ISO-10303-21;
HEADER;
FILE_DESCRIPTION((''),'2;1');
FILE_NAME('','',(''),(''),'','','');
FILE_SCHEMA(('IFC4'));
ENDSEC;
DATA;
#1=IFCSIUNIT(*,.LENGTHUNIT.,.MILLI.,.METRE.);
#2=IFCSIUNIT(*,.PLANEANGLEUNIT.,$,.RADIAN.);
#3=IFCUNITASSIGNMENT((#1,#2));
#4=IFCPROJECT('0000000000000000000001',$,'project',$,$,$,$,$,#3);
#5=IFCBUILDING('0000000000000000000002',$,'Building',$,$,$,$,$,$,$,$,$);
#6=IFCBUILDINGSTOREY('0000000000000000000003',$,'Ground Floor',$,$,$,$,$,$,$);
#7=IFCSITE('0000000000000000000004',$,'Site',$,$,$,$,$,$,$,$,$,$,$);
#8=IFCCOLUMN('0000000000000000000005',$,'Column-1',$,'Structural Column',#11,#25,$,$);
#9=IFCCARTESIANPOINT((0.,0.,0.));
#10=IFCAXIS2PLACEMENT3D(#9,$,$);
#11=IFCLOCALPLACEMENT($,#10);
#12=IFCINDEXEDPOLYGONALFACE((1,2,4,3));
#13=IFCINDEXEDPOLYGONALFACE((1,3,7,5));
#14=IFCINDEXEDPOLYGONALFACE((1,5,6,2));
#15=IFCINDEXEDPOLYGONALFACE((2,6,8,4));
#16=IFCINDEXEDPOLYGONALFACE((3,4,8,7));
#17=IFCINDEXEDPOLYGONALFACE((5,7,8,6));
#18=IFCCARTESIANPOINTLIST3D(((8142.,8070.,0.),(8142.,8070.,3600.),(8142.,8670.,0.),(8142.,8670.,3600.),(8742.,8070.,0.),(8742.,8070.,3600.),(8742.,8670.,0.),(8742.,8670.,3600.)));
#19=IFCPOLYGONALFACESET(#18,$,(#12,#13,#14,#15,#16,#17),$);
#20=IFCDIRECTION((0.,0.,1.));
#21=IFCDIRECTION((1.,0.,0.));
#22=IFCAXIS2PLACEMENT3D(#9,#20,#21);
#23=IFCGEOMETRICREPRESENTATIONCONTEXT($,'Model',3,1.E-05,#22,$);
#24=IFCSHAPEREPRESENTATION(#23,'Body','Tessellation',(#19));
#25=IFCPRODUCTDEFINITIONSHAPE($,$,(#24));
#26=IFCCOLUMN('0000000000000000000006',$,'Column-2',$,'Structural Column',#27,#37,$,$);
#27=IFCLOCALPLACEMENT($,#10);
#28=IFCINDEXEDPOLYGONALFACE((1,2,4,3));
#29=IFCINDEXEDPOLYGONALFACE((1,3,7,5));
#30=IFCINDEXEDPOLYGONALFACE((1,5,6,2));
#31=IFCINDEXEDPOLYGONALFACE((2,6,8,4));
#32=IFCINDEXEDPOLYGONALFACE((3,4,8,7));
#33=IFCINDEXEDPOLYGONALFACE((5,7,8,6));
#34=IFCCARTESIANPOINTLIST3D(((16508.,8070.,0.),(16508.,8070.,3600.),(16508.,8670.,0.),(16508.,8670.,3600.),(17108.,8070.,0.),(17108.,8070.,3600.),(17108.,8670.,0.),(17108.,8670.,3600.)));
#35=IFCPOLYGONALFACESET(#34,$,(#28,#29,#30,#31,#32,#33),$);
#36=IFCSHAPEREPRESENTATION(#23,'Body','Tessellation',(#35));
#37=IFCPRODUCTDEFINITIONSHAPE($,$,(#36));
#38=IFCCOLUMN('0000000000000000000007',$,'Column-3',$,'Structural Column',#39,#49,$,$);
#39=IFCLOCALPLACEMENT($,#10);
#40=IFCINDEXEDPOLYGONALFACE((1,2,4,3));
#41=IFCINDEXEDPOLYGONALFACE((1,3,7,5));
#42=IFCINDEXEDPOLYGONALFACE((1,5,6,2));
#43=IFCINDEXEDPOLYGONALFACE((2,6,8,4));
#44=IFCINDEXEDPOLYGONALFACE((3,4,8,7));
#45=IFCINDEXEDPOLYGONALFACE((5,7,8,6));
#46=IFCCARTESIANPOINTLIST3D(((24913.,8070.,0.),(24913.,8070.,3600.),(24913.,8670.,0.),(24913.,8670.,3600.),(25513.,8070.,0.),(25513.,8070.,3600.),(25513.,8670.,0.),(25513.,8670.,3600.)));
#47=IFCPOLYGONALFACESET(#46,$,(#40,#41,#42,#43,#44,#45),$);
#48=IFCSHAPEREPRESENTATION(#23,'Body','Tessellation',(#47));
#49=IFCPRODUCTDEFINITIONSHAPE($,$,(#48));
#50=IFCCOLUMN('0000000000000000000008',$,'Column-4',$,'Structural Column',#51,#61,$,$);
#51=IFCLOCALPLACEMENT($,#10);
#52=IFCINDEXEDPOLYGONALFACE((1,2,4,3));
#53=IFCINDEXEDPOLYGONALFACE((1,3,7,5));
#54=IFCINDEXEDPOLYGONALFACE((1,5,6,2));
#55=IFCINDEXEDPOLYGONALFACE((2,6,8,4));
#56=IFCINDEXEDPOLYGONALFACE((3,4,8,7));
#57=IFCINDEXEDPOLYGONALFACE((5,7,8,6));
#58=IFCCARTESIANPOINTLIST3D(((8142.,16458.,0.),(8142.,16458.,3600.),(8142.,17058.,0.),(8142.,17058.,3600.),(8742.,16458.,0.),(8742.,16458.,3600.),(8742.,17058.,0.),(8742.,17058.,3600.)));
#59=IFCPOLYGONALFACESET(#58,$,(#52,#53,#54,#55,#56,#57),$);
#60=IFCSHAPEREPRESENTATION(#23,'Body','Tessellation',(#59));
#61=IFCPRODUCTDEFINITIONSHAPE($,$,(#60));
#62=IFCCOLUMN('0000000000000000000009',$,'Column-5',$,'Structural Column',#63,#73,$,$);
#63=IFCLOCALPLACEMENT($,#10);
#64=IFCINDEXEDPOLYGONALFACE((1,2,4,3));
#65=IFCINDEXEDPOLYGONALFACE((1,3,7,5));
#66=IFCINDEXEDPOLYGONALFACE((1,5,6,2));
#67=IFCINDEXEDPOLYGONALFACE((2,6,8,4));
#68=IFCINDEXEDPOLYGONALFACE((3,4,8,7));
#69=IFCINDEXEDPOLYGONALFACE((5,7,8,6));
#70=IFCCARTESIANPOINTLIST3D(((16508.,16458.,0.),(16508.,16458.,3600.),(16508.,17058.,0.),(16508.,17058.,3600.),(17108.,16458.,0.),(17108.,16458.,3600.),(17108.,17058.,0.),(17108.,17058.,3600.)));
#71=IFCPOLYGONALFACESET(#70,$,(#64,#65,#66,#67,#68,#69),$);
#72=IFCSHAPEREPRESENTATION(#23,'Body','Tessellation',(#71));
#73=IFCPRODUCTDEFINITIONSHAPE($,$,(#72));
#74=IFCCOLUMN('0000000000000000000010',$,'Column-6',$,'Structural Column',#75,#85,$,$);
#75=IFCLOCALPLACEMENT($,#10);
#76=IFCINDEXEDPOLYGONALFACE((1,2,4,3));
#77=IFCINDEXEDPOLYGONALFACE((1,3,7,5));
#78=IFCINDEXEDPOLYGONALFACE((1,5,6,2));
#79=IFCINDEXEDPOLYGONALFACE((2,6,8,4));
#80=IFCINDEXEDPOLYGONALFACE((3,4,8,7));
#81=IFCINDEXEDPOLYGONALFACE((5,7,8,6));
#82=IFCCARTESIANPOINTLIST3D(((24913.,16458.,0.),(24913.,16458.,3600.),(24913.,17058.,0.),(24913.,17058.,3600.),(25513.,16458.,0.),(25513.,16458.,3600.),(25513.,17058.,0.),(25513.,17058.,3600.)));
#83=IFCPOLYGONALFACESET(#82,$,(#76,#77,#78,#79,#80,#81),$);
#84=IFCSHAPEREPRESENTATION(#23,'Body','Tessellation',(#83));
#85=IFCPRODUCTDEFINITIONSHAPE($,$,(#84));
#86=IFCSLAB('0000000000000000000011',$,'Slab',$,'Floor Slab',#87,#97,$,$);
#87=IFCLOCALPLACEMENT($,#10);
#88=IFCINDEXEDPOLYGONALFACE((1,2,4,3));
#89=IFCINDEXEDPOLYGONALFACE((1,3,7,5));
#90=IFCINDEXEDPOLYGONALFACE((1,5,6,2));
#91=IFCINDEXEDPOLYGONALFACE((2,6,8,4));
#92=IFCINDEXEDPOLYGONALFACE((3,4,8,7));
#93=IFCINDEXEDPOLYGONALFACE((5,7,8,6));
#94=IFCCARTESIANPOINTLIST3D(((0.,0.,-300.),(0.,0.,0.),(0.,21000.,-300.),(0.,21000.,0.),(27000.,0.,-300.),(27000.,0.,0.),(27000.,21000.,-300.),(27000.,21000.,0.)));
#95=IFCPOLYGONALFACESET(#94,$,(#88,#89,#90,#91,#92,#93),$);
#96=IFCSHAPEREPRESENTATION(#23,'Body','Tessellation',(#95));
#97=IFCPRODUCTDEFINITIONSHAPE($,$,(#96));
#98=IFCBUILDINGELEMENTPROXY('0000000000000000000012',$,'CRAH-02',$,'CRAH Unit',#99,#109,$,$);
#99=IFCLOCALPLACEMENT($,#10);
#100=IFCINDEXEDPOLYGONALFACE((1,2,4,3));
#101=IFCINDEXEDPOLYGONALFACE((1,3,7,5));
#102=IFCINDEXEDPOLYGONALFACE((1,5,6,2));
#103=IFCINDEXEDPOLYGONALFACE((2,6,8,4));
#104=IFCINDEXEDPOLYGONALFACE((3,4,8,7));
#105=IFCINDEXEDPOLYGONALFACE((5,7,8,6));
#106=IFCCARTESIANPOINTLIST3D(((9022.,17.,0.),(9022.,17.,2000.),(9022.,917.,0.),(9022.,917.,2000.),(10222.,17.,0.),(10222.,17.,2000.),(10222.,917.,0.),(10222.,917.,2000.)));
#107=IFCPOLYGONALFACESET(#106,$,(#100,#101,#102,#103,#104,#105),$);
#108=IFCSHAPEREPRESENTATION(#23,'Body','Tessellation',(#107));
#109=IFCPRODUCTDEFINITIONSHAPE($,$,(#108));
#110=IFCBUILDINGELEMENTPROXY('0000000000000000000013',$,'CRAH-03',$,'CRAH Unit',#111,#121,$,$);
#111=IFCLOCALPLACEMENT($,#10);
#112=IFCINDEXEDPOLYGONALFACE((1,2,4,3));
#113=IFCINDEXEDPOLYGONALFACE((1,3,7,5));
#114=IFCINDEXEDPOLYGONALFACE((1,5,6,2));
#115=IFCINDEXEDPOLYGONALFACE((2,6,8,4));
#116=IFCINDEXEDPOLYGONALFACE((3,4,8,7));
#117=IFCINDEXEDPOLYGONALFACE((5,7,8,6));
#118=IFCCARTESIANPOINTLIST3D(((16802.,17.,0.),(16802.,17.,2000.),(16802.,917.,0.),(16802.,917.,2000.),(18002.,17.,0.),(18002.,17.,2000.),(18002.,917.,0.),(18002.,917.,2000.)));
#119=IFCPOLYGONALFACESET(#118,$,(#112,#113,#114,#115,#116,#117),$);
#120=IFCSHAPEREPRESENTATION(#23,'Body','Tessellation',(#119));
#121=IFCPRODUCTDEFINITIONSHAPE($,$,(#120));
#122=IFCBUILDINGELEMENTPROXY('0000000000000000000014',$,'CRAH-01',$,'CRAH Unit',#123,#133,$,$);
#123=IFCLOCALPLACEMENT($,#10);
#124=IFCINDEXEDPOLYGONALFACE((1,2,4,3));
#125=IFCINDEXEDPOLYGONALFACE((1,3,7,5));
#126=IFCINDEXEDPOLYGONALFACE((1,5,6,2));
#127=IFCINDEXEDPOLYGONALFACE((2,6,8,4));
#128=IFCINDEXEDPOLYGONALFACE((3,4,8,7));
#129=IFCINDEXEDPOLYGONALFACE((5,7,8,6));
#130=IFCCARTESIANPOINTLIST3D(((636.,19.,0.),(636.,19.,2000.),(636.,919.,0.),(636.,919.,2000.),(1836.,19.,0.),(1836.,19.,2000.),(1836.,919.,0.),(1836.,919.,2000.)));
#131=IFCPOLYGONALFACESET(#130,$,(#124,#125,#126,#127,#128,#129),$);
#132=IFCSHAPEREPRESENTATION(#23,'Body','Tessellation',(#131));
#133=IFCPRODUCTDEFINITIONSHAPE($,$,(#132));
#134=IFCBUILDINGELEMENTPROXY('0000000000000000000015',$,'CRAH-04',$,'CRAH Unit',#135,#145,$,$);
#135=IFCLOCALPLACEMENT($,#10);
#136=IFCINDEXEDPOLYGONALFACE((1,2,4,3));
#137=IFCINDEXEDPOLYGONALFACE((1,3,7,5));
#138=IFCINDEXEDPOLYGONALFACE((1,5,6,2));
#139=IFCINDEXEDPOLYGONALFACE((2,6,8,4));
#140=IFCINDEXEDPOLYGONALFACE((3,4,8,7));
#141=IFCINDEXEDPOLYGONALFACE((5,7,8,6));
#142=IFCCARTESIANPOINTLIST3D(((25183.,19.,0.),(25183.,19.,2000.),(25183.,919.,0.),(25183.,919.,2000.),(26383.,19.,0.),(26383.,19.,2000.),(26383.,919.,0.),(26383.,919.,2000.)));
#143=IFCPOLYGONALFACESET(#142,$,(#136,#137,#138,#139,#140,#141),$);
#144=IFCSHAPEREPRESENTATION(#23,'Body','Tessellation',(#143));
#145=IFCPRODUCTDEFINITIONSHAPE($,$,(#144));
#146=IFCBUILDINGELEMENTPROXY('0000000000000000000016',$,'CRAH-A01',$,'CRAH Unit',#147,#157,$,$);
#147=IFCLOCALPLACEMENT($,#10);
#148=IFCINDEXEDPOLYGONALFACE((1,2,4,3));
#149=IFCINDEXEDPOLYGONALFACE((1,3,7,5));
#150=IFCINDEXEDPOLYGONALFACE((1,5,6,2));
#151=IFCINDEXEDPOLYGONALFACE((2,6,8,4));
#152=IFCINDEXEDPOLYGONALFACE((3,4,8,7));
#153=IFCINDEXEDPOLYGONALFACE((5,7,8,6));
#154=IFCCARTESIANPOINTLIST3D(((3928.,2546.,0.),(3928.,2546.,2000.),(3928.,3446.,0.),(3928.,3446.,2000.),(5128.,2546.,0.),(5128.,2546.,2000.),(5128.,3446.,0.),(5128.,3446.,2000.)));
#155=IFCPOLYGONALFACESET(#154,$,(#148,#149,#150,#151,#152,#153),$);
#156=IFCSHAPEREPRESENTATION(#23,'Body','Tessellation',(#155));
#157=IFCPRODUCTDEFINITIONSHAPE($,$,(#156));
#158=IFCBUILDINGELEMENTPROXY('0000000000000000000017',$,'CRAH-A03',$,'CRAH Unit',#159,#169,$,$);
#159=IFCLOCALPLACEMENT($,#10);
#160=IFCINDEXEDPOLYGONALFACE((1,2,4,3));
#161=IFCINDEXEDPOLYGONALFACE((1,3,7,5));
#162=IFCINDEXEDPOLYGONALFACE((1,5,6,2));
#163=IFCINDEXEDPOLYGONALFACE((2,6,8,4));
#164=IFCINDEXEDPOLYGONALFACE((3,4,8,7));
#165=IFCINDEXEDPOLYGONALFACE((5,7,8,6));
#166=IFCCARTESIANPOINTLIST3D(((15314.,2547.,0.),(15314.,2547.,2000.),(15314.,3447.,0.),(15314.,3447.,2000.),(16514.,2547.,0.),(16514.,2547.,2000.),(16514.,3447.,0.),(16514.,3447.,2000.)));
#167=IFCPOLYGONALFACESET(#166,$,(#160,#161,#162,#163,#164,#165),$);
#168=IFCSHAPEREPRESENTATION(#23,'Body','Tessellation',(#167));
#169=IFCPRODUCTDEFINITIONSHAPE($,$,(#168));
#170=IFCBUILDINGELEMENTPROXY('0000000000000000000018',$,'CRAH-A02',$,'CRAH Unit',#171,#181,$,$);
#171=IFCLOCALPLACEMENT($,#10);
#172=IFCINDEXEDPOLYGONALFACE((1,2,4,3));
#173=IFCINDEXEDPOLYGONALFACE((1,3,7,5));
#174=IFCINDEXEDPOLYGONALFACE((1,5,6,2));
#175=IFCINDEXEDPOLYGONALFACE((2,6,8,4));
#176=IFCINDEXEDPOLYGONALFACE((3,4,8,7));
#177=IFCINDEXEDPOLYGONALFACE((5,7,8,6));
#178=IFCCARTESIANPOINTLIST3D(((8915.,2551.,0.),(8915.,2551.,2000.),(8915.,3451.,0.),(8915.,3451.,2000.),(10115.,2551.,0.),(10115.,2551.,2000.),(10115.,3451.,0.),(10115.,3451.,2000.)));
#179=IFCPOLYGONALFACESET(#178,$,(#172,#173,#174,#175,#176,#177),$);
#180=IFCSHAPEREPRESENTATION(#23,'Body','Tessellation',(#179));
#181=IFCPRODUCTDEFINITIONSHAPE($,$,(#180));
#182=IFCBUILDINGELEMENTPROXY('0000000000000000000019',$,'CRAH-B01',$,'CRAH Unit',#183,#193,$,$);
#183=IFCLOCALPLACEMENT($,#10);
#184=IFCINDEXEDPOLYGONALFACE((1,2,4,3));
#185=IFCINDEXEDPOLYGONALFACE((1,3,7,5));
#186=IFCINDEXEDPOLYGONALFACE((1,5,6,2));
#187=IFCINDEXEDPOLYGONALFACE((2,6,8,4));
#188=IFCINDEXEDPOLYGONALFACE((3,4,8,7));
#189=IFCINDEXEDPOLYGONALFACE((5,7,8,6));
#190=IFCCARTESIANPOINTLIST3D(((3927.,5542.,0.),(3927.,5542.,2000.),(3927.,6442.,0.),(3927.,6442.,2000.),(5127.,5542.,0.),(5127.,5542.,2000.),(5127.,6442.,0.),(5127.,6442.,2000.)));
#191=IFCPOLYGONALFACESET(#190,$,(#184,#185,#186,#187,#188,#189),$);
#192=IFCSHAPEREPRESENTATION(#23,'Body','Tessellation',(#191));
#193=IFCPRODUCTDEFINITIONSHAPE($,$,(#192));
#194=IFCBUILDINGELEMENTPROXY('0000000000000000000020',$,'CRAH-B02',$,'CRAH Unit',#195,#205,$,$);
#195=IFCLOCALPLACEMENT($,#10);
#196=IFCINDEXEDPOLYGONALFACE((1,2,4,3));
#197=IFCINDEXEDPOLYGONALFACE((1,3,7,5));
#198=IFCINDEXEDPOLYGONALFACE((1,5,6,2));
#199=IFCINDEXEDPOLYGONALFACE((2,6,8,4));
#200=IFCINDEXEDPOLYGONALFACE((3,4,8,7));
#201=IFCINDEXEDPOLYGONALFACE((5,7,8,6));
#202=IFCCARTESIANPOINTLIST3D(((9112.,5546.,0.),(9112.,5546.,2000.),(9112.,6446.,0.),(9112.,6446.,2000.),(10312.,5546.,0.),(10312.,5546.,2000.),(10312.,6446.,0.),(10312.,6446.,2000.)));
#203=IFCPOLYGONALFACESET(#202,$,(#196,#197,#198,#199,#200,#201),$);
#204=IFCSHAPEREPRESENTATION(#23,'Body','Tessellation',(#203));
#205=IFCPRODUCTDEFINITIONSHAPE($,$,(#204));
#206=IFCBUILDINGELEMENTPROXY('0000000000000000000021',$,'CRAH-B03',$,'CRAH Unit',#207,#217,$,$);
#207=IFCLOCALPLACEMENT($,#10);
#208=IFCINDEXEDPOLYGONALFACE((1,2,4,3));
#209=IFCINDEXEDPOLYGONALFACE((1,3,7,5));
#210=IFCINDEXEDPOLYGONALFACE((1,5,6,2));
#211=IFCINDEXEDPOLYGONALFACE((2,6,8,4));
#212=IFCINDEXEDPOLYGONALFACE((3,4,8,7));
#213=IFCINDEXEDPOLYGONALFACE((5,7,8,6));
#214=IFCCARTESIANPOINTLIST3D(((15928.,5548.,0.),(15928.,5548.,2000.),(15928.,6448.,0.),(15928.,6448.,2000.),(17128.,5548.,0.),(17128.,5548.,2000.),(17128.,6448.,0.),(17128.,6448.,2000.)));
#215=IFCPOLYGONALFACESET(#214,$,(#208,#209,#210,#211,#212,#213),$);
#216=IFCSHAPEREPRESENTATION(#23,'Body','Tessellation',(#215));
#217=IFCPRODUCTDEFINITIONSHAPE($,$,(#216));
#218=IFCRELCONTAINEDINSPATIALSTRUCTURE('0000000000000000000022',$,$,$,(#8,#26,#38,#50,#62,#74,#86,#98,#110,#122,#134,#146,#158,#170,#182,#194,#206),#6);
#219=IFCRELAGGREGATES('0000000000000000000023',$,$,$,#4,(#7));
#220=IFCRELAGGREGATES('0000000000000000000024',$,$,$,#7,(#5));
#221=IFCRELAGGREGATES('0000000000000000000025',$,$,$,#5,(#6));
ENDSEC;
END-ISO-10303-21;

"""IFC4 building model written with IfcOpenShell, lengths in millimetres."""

from ifc_helpers import new_model, si_unit, frame, origin_with_axes, place, context, project, spatial, rectangle, extrude, element, save


model = new_model("IFC4")

# Units and contexts
model_context = context("Model", 3, precision=1e-05, world=origin_with_axes())
ifc_project = project(units=[si_unit("LENGTHUNIT", "METRE", prefix="MILLI"), si_unit("PLANEANGLEUNIT", "RADIAN")])

# Site, building, storey
site = spatial("IfcSite", under=ifc_project, Name="Site")
building = spatial("IfcBuilding", under=site, Name="Building")
storey = spatial("IfcBuildingStorey", under=building, Name="Ground Floor")

# Columns
column_1_placement = place(None, origin_with_axes())
element("IfcColumn", 1, at=column_1_placement, inside=storey, Name="Column-1", ObjectType="Structural Column", context=model_context, shape_type="SweptSolid", body=[
    extrude(rectangle(XDim=600.0, YDim=600.0), frame((8442.0, 8370.0, 0.0), z_axis=(0.0, 0.0, 1.0), x_axis=(1.0, 0.0, 0.0)), (0.0, 0.0, 1.0), 3600.0),
])
column_2_placement = place(None, origin_with_axes())
element("IfcColumn", 2, at=column_2_placement, inside=storey, Name="Column-2", ObjectType="Structural Column", context=model_context, shape_type="SweptSolid", body=[
    extrude(rectangle(XDim=600.0, YDim=600.0), frame((16808.0, 8370.0, 0.0), z_axis=(0.0, 0.0, 1.0), x_axis=(1.0, 0.0, 0.0)), (0.0, 0.0, 1.0), 3600.0),
])
column_3_placement = place(None, origin_with_axes())
element("IfcColumn", 3, at=column_3_placement, inside=storey, Name="Column-3", ObjectType="Structural Column", context=model_context, shape_type="SweptSolid", body=[
    extrude(rectangle(XDim=600.0, YDim=600.0), frame((25213.0, 8370.0, 0.0), z_axis=(0.0, 0.0, 1.0), x_axis=(1.0, 0.0, 0.0)), (0.0, 0.0, 1.0), 3600.0),
])
column_4_placement = place(None, origin_with_axes())
element("IfcColumn", 4, at=column_4_placement, inside=storey, Name="Column-4", ObjectType="Structural Column", context=model_context, shape_type="SweptSolid", body=[
    extrude(rectangle(XDim=600.0, YDim=600.0), frame((8442.0, 16758.0, 0.0), z_axis=(0.0, 0.0, 1.0), x_axis=(1.0, 0.0, 0.0)), (0.0, 0.0, 1.0), 3600.0),
])
column_5_placement = place(None, origin_with_axes())
element("IfcColumn", 5, at=column_5_placement, inside=storey, Name="Column-5", ObjectType="Structural Column", context=model_context, shape_type="SweptSolid", body=[
    extrude(rectangle(XDim=600.0, YDim=600.0), frame((16808.0, 16758.0, 0.0), z_axis=(0.0, 0.0, 1.0), x_axis=(1.0, 0.0, 0.0)), (0.0, 0.0, 1.0), 3600.0),
])
column_6_placement = place(None, origin_with_axes())
element("IfcColumn", 6, at=column_6_placement, inside=storey, Name="Column-6", ObjectType="Structural Column", context=model_context, shape_type="SweptSolid", body=[
    extrude(rectangle(XDim=600.0, YDim=600.0), frame((25213.0, 16758.0, 0.0), z_axis=(0.0, 0.0, 1.0), x_axis=(1.0, 0.0, 0.0)), (0.0, 0.0, 1.0), 3600.0),
])

# Slab
slab_placement = place(None, origin_with_axes())
element("IfcSlab", 7, at=slab_placement, inside=storey, Name="Slab", ObjectType="Floor Slab", context=model_context, shape_type="SweptSolid", body=[
    extrude(rectangle(XDim=27000.0, YDim=21000.0), frame((13500.0, 10500.0, -300.0), z_axis=(0.0, 0.0, 1.0), x_axis=(1.0, 0.0, 0.0)), (0.0, 0.0, 1.0), 300.0),
])

# Building element proxies
proxy_1_placement = place(None, origin_with_axes())
element("IfcBuildingElementProxy", 8, at=proxy_1_placement, inside=storey, Name="CRAH-02", ObjectType="CRAH Unit", context=model_context, shape_type="SweptSolid", body=[
    extrude(rectangle(XDim=1200.0, YDim=900.0), frame((9622.0, 467.0, 0.0), z_axis=(0.0, 0.0, 1.0), x_axis=(1.0, 0.0, 0.0)), (0.0, 0.0, 1.0), 2000.0),
])
proxy_2_placement = place(None, origin_with_axes())
element("IfcBuildingElementProxy", 9, at=proxy_2_placement, inside=storey, Name="CRAH-03", ObjectType="CRAH Unit", context=model_context, shape_type="SweptSolid", body=[
    extrude(rectangle(XDim=1200.0, YDim=900.0), frame((17402.0, 467.0, 0.0), z_axis=(0.0, 0.0, 1.0), x_axis=(1.0, 0.0, 0.0)), (0.0, 0.0, 1.0), 2000.0),
])
proxy_3_placement = place(None, origin_with_axes())
element("IfcBuildingElementProxy", 10, at=proxy_3_placement, inside=storey, Name="CRAH-01", ObjectType="CRAH Unit", context=model_context, shape_type="SweptSolid", body=[
    extrude(rectangle(XDim=1200.0, YDim=900.0), frame((1236.0, 469.0, 0.0), z_axis=(0.0, 0.0, 1.0), x_axis=(1.0, 0.0, 0.0)), (0.0, 0.0, 1.0), 2000.0),
])
proxy_4_placement = place(None, origin_with_axes())
element("IfcBuildingElementProxy", 11, at=proxy_4_placement, inside=storey, Name="CRAH-04", ObjectType="CRAH Unit", context=model_context, shape_type="SweptSolid", body=[
    extrude(rectangle(XDim=1200.0, YDim=900.0), frame((25783.0, 469.0, 0.0), z_axis=(0.0, 0.0, 1.0), x_axis=(1.0, 0.0, 0.0)), (0.0, 0.0, 1.0), 2000.0),
])
proxy_5_placement = place(None, origin_with_axes())
element("IfcBuildingElementProxy", 12, at=proxy_5_placement, inside=storey, Name="CRAH-A01", ObjectType="CRAH Unit", context=model_context, shape_type="SweptSolid", body=[
    extrude(rectangle(XDim=1200.0, YDim=900.0), frame((4528.0, 2996.0, 0.0), z_axis=(0.0, 0.0, 1.0), x_axis=(1.0, 0.0, 0.0)), (0.0, 0.0, 1.0), 2000.0),
])
proxy_6_placement = place(None, origin_with_axes())
element("IfcBuildingElementProxy", 13, at=proxy_6_placement, inside=storey, Name="CRAH-A03", ObjectType="CRAH Unit", context=model_context, shape_type="SweptSolid", body=[
    extrude(rectangle(XDim=1200.0, YDim=900.0), frame((15914.0, 2997.0, 0.0), z_axis=(0.0, 0.0, 1.0), x_axis=(1.0, 0.0, 0.0)), (0.0, 0.0, 1.0), 2000.0),
])
proxy_7_placement = place(None, origin_with_axes())
element("IfcBuildingElementProxy", 14, at=proxy_7_placement, inside=storey, Name="CRAH-A02", ObjectType="CRAH Unit", context=model_context, shape_type="SweptSolid", body=[
    extrude(rectangle(XDim=1200.0, YDim=900.0), frame((9515.0, 3001.0, 0.0), z_axis=(0.0, 0.0, 1.0), x_axis=(1.0, 0.0, 0.0)), (0.0, 0.0, 1.0), 2000.0),
])
proxy_8_placement = place(None, origin_with_axes())
element("IfcBuildingElementProxy", 15, at=proxy_8_placement, inside=storey, Name="CRAH-B01", ObjectType="CRAH Unit", context=model_context, shape_type="SweptSolid", body=[
    extrude(rectangle(XDim=1200.0, YDim=900.0), frame((4527.0, 5992.0, 0.0), z_axis=(0.0, 0.0, 1.0), x_axis=(1.0, 0.0, 0.0)), (0.0, 0.0, 1.0), 2000.0),
])
proxy_9_placement = place(None, origin_with_axes())
element("IfcBuildingElementProxy", 16, at=proxy_9_placement, inside=storey, Name="CRAH-B02", ObjectType="CRAH Unit", context=model_context, shape_type="SweptSolid", body=[
    extrude(rectangle(XDim=1200.0, YDim=900.0), frame((9712.0, 5996.0, 0.0), z_axis=(0.0, 0.0, 1.0), x_axis=(1.0, 0.0, 0.0)), (0.0, 0.0, 1.0), 2000.0),
])
proxy_10_placement = place(None, origin_with_axes())
element("IfcBuildingElementProxy", 17, at=proxy_10_placement, inside=storey, Name="CRAH-B03", ObjectType="CRAH Unit", context=model_context, shape_type="SweptSolid", body=[
    extrude(rectangle(XDim=1200.0, YDim=900.0), frame((16528.0, 5998.0, 0.0), z_axis=(0.0, 0.0, 1.0), x_axis=(1.0, 0.0, 0.0)), (0.0, 0.0, 1.0), 2000.0),
])

save(model, "model.ifc")
